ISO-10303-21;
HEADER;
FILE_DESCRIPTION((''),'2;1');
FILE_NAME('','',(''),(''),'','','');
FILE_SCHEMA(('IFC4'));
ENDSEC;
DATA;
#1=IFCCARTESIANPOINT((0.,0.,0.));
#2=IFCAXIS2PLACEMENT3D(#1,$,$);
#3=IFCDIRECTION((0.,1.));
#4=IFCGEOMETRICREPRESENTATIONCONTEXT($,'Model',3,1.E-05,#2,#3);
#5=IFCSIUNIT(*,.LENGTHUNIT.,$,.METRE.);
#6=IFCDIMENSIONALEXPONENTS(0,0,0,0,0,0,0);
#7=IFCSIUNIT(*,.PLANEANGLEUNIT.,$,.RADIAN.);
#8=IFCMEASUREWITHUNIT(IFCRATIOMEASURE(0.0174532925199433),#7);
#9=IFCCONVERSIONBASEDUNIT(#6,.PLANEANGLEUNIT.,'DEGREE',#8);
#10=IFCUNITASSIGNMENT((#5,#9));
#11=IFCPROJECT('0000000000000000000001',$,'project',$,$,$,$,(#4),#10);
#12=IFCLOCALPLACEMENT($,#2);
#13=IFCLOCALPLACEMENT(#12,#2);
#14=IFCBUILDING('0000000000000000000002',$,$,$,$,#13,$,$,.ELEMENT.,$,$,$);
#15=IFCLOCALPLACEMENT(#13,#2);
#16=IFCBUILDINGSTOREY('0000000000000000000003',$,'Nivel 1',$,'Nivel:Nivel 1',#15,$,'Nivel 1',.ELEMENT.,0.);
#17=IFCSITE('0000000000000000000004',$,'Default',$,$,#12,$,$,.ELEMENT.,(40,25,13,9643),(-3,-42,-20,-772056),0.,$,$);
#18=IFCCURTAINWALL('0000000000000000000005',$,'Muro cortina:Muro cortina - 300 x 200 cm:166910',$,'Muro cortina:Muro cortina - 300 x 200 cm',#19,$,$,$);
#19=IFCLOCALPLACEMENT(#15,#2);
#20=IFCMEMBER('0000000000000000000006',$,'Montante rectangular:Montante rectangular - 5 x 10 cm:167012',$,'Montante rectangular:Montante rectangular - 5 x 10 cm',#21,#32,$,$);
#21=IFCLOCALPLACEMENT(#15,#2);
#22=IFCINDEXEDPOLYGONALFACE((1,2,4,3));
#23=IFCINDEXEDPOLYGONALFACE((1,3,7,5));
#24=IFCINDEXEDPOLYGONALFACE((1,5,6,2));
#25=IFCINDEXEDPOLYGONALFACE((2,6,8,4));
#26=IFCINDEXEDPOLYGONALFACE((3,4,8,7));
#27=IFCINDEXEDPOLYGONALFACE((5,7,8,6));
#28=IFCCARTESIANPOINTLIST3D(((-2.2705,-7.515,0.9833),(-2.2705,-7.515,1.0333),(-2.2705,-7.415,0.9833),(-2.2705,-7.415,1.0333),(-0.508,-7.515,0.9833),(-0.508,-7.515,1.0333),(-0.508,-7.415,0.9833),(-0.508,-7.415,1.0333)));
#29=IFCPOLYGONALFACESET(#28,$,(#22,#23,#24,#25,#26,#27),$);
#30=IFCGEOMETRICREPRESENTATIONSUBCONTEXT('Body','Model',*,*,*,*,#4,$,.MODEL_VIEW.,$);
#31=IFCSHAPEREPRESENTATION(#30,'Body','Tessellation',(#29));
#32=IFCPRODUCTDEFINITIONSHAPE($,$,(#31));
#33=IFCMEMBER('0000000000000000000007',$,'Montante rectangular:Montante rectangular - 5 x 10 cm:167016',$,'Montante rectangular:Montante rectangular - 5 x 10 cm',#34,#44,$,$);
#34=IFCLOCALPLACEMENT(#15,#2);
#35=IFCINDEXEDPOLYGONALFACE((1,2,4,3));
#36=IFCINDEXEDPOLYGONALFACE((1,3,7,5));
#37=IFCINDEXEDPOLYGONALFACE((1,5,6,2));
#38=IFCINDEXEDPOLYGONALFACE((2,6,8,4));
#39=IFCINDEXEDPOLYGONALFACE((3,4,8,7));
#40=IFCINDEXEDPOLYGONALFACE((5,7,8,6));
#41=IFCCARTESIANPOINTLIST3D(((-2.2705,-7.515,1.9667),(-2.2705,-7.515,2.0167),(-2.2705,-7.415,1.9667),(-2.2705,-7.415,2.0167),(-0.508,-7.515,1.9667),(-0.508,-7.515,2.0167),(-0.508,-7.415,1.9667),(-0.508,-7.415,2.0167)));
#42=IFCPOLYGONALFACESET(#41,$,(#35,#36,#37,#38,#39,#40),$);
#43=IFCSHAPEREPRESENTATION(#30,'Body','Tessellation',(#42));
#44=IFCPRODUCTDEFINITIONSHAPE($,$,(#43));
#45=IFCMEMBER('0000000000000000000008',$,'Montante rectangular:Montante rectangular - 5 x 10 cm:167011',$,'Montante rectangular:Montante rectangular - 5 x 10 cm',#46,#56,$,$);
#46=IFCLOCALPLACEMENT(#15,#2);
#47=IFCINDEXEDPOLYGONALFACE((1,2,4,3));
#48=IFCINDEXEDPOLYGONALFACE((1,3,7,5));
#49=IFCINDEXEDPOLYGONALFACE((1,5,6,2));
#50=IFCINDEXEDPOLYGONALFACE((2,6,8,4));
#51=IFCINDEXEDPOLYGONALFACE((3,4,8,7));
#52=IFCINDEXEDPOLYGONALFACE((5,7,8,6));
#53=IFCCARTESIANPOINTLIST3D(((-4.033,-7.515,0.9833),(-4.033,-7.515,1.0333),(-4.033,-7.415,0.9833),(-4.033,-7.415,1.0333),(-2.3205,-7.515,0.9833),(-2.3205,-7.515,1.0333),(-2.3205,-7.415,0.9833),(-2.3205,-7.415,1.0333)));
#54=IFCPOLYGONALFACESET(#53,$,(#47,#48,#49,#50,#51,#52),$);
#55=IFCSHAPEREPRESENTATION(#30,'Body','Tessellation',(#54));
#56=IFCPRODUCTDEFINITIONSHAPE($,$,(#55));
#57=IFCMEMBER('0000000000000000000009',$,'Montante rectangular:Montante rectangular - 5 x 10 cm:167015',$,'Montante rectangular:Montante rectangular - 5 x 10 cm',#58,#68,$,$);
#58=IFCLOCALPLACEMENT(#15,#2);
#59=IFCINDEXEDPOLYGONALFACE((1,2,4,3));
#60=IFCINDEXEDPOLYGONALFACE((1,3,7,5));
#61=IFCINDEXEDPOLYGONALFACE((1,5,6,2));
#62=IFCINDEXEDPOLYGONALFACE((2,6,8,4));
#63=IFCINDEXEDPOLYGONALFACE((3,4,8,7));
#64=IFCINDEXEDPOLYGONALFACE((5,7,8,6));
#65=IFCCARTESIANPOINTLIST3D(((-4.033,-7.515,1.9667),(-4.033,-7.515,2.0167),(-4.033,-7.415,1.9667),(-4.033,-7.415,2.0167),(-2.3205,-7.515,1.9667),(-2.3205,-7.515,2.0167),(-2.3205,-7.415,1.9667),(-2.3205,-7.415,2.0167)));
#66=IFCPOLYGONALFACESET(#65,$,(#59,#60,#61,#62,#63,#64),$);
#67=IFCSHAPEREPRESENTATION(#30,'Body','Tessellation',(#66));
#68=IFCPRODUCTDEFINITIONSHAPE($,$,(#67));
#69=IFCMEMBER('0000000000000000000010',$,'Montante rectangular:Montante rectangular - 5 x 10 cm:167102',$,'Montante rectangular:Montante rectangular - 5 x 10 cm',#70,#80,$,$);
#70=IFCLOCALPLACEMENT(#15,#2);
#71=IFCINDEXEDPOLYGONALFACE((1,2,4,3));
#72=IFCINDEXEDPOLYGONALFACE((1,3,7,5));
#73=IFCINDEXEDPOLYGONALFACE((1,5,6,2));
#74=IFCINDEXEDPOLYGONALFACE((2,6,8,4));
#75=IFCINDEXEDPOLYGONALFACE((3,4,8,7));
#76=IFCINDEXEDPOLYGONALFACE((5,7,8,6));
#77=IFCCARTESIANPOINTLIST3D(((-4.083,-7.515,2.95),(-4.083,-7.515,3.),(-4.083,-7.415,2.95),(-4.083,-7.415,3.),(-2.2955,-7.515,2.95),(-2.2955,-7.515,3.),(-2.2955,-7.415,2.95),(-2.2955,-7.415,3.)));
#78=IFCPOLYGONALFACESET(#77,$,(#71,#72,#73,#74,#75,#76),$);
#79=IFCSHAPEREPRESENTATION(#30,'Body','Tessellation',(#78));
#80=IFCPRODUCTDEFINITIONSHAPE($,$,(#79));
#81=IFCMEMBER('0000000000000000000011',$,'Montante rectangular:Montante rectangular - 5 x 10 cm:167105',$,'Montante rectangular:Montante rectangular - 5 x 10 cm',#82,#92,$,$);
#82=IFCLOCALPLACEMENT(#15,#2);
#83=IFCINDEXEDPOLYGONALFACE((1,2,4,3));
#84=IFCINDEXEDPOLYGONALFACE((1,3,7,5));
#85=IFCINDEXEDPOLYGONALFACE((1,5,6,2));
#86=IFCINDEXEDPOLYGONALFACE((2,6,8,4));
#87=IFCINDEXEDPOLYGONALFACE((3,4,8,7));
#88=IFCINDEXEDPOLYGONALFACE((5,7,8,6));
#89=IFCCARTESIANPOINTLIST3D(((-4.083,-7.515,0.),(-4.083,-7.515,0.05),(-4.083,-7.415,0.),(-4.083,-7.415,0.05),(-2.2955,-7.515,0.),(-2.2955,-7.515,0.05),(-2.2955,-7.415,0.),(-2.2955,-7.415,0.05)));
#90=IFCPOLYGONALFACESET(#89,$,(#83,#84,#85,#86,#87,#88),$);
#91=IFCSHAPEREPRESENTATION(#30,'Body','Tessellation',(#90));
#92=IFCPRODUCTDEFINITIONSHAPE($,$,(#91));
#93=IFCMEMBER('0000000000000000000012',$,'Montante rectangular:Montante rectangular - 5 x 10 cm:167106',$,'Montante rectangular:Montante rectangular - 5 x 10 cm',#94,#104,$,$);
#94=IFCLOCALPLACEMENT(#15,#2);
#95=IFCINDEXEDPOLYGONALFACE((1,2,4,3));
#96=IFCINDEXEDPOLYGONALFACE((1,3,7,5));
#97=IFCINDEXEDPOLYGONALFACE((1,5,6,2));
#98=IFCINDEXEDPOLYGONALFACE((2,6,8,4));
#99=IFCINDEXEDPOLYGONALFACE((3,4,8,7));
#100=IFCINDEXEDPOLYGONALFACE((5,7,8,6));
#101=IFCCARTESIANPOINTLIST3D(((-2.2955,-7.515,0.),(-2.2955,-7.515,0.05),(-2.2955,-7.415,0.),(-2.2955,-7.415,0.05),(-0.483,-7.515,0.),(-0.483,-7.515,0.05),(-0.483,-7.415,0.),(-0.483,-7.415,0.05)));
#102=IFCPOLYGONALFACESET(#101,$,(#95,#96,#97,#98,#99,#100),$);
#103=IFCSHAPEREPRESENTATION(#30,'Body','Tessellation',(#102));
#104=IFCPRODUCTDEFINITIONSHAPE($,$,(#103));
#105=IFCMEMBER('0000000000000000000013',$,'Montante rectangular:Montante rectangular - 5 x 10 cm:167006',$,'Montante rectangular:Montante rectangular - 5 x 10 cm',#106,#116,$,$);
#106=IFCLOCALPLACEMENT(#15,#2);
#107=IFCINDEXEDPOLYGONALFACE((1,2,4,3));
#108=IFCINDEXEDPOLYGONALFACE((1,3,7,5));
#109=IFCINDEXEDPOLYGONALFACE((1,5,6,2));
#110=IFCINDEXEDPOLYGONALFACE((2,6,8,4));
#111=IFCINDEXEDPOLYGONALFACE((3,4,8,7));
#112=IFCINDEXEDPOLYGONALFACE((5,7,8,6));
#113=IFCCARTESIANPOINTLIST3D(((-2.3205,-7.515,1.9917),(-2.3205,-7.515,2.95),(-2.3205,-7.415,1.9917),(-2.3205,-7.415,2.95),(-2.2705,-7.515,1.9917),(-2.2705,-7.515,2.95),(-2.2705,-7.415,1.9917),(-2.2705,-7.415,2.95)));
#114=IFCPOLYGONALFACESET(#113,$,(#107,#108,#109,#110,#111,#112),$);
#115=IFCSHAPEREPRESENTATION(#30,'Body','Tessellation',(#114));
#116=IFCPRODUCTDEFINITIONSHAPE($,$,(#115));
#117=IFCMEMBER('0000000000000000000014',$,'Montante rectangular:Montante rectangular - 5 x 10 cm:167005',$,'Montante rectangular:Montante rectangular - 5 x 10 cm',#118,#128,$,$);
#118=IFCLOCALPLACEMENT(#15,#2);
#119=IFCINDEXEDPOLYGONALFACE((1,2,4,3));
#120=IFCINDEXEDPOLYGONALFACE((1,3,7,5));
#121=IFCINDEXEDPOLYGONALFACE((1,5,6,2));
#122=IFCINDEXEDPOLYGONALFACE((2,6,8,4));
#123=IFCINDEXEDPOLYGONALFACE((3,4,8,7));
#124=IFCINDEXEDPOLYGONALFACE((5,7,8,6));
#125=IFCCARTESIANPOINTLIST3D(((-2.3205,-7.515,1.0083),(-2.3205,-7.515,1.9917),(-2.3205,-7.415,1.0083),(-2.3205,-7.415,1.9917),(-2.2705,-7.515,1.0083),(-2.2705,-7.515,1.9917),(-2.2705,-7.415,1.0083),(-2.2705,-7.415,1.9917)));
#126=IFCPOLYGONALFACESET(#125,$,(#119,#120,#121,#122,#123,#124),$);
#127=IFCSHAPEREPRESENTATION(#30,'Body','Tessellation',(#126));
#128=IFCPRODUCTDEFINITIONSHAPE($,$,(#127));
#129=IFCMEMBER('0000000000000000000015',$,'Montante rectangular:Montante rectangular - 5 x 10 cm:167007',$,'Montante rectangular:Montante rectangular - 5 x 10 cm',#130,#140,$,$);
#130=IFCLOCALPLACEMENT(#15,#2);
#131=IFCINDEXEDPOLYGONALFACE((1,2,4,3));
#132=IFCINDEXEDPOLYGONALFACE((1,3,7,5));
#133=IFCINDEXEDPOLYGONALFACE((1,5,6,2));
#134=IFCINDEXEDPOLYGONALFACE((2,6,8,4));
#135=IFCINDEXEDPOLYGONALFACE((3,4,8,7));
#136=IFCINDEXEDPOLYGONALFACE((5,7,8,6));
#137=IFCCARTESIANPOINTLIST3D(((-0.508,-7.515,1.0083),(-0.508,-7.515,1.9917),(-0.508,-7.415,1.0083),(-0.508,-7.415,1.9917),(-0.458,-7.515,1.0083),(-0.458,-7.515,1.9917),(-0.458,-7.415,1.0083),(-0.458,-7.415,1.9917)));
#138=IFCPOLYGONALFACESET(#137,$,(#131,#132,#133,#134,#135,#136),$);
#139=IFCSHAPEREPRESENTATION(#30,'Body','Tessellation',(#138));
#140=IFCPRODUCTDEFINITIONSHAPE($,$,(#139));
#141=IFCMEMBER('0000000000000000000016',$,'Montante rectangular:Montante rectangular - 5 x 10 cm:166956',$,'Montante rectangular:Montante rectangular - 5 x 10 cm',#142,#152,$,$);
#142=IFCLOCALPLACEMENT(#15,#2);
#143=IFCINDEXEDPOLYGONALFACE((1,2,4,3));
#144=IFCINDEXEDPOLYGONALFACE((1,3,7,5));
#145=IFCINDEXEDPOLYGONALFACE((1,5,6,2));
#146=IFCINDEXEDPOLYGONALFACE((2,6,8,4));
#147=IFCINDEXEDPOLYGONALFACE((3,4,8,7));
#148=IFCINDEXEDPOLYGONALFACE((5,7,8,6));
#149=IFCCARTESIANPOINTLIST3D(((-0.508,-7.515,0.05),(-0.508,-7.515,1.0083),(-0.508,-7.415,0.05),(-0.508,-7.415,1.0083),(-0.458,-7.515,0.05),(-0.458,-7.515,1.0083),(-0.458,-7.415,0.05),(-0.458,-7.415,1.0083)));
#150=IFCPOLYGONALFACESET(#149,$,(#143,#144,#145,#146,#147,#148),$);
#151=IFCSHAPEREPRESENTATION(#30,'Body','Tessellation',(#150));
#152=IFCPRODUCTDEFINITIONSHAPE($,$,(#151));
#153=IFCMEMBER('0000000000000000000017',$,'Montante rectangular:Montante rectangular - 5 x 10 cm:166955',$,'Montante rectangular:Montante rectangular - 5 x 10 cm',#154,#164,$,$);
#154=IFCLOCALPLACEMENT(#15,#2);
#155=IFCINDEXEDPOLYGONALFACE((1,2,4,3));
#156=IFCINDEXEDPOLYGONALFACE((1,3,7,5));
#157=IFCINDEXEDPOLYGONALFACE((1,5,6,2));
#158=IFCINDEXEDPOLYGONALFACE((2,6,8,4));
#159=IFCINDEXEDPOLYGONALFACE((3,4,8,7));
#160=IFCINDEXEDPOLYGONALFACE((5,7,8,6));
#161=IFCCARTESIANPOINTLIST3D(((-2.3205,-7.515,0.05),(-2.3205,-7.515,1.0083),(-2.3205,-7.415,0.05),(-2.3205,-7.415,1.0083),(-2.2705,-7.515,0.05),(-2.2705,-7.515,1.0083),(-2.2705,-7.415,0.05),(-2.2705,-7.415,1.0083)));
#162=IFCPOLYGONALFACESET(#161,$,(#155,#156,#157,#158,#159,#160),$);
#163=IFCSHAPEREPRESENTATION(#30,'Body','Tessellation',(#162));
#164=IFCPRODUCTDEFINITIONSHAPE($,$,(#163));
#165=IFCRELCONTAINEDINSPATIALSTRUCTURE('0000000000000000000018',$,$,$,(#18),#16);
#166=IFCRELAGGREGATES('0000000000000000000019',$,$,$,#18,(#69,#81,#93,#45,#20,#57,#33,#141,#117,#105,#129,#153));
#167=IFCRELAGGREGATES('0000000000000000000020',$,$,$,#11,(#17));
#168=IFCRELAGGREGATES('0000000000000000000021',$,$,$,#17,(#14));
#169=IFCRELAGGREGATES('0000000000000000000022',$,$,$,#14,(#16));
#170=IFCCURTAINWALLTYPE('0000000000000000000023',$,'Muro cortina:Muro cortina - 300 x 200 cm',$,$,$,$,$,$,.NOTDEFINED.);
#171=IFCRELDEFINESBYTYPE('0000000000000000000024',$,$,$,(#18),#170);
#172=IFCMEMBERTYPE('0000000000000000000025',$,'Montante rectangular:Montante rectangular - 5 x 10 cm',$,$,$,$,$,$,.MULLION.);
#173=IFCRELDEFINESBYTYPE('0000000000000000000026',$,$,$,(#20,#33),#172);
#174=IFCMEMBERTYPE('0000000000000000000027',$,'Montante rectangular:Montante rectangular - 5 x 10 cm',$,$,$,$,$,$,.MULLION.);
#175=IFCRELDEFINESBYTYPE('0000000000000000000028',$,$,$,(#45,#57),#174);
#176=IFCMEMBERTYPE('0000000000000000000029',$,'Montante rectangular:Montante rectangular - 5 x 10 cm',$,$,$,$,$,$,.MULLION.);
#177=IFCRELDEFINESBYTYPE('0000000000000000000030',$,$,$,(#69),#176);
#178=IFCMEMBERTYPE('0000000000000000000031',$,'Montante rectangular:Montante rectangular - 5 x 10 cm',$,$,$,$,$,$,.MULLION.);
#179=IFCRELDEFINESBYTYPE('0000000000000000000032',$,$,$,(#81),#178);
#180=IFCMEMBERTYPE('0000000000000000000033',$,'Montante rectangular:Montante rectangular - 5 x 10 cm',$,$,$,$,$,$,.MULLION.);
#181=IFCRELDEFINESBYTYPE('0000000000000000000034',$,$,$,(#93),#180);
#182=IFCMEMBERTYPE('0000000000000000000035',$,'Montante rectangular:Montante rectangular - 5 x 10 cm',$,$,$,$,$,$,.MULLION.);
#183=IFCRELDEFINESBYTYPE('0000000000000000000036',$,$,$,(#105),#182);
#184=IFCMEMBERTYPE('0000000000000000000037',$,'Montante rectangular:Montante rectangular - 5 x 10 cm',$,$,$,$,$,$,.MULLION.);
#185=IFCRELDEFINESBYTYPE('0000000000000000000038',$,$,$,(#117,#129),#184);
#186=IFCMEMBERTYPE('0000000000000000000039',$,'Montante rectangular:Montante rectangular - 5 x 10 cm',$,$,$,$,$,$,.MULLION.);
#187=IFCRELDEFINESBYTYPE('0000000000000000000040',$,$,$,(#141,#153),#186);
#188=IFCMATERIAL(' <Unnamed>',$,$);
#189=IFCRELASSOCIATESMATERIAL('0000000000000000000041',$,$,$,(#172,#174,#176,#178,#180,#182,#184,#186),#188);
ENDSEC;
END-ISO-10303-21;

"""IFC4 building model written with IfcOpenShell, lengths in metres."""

from ifc_helpers import new_model, entity, si_unit, converted_unit, direction, frame, origin, origin_2d_with_axis, place, context, subcontext, project, spatial, rectangle, extrude, source, transform, mapped, material, type_object, type_shapes, element, aggregate, save


model = new_model("IFC4")

# Units and contexts
model_context = context("Model", 3, precision=1e-05, world=origin(), true_north=direction((0.0, 1.0)))
body_context = subcontext(model_context, "Body", "Model", "MODEL_VIEW")
ifc_project = project(units=[si_unit("LENGTHUNIT", "METRE"), converted_unit("PLANEANGLEUNIT", "DEGREE", entity("IfcRatioMeasure", 0.0174532925199433), si_unit("PLANEANGLEUNIT", "RADIAN"), dimensions=[0, 0, 0, 0, 0, 0, 0])], contexts=[model_context])

# Site, building, storey
site_placement = place(None, origin())
site = spatial("IfcSite", under=ifc_project, at=site_placement, Name="Default", CompositionType="ELEMENT", RefLatitude=(40, 25, 13, 9643), RefLongitude=(-3, -42, -20, -772056), RefElevation=0.0)
building_placement = place(site_placement, origin())
building = spatial("IfcBuilding", under=site, at=building_placement, CompositionType="ELEMENT")
storey_placement = place(building_placement, origin())
storey = spatial("IfcBuildingStorey", under=building, at=storey_placement, Name="Nivel 1", ObjectType="Nivel:Nivel 1", LongName="Nivel 1", CompositionType="ELEMENT", Elevation=0.0)

# Curtain wall, members
curtain_wall_type = type_object("IfcCurtainWallType", Name="Muro cortina:Muro cortina - 300 x 200 cm", PredefinedType="NOTDEFINED")
curtain_wall_placement = place(storey_placement, origin())
curtain_wall = element("IfcCurtainWall", 1, at=curtain_wall_placement, inside=storey, type_object=curtain_wall_type, Name="Muro cortina:Muro cortina - 300 x 200 cm:166910", ObjectType="Muro cortina:Muro cortina - 300 x 200 cm")
ifc_material_1 = material(Name=" <Unnamed>")
member_type_1 = type_object("IfcMemberType", Name="Montante rectangular:Montante rectangular - 5 x 10 cm", PredefinedType="MULLION", material=ifc_material_1)
shared_shape_1 = source(origin(), body_context, "Body", "SweptSolid", [
    extrude(rectangle(XDim=0.1, YDim=0.05, at=origin_2d_with_axis()), frame((0.0, 0.0, -1.7625), z_axis=(0.0, 0.0, 1.0), x_axis=(0.0, -1.0, 0.0)), (0.0, 0.0, 1.0), 1.7625),
])
type_shapes(member_type_1, [shared_shape_1])
member_1_placement = place(storey_placement, frame((-0.508, -7.465, 1.0083), z_axis=(1.0, 0.0, 0.0), x_axis=(0.0, 0.0, 1.0)))
member_1 = element("IfcMember", 2, at=member_1_placement, type_object=member_type_1, Name="Montante rectangular:Montante rectangular - 5 x 10 cm:167012", ObjectType="Montante rectangular:Montante rectangular - 5 x 10 cm", context=body_context, shape_type="MappedRepresentation", body=[
    mapped(shared_shape_1, transform((0.0, 0.0, 0.0), scale=1.0)),
])
member_2_placement = place(storey_placement, frame((-0.508, -7.465, 1.9917), z_axis=(1.0, 0.0, 0.0), x_axis=(0.0, 0.0, 1.0)))
member_2 = element("IfcMember", 3, at=member_2_placement, type_object=member_type_1, Name="Montante rectangular:Montante rectangular - 5 x 10 cm:167016", ObjectType="Montante rectangular:Montante rectangular - 5 x 10 cm", context=body_context, shape_type="MappedRepresentation", body=[
    mapped(shared_shape_1, transform((0.0, 0.0, 0.0), scale=1.0)),
])
member_type_2 = type_object("IfcMemberType", Name="Montante rectangular:Montante rectangular - 5 x 10 cm", PredefinedType="MULLION", material=ifc_material_1)
shared_shape_2 = source(origin(), body_context, "Body", "SweptSolid", [
    extrude(rectangle(XDim=0.1, YDim=0.05, at=origin_2d_with_axis()), frame((0.0, 0.0, -1.7125), z_axis=(0.0, 0.0, 1.0), x_axis=(0.0, -1.0, 0.0)), (0.0, 0.0, 1.0), 1.7125),
])
type_shapes(member_type_2, [shared_shape_2])
member_3_placement = place(storey_placement, frame((-2.3205, -7.465, 1.0083), z_axis=(1.0, 0.0, 0.0), x_axis=(0.0, 0.0, 1.0)))
member_3 = element("IfcMember", 4, at=member_3_placement, type_object=member_type_2, Name="Montante rectangular:Montante rectangular - 5 x 10 cm:167011", ObjectType="Montante rectangular:Montante rectangular - 5 x 10 cm", context=body_context, shape_type="MappedRepresentation", body=[
    mapped(shared_shape_2, transform((0.0, 0.0, 0.0), scale=1.0)),
])
member_4_placement = place(storey_placement, frame((-2.3205, -7.465, 1.9917), z_axis=(1.0, 0.0, 0.0), x_axis=(0.0, 0.0, 1.0)))
member_4 = element("IfcMember", 5, at=member_4_placement, type_object=member_type_2, Name="Montante rectangular:Montante rectangular - 5 x 10 cm:167015", ObjectType="Montante rectangular:Montante rectangular - 5 x 10 cm", context=body_context, shape_type="MappedRepresentation", body=[
    mapped(shared_shape_2, transform((0.0, 0.0, 0.0), scale=1.0)),
])
member_type_3 = type_object("IfcMemberType", Name="Montante rectangular:Montante rectangular - 5 x 10 cm", PredefinedType="MULLION", material=ifc_material_1)
shared_shape_3 = source(origin(), body_context, "Body", "SweptSolid", [
    extrude(rectangle(XDim=0.1, YDim=0.05, at=origin_2d_with_axis()), frame((-0.025, 0.0, -1.7875), z_axis=(0.0, 0.0, 1.0), x_axis=(0.0, -1.0, 0.0)), (0.0, 0.0, 1.0), 1.7875),
])
type_shapes(member_type_3, [shared_shape_3])
member_5_placement = place(storey_placement, frame((-2.2955, -7.465, 3.0), z_axis=(1.0, 0.0, 0.0), x_axis=(0.0, 0.0, 1.0)))
member_5 = element("IfcMember", 6, at=member_5_placement, type_object=member_type_3, Name="Montante rectangular:Montante rectangular - 5 x 10 cm:167102", ObjectType="Montante rectangular:Montante rectangular - 5 x 10 cm", context=body_context, shape_type="MappedRepresentation", body=[
    mapped(shared_shape_3, transform((0.0, 0.0, 0.0), scale=1.0)),
])
member_type_4 = type_object("IfcMemberType", Name="Montante rectangular:Montante rectangular - 5 x 10 cm", PredefinedType="MULLION", material=ifc_material_1)
shared_shape_4 = source(origin(), body_context, "Body", "SweptSolid", [
    extrude(rectangle(XDim=0.1, YDim=0.05, at=origin_2d_with_axis()), frame((-0.025, 0.0, -1.7875), z_axis=(0.0, 0.0, 1.0), x_axis=(0.0, -1.0, 0.0)), (0.0, 0.0, 1.0), 1.7875),
])
type_shapes(member_type_4, [shared_shape_4])
member_6_placement = place(storey_placement, frame((-4.083, -7.465, 0.0), z_axis=(-1.0, 0.0, 0.0), x_axis=(0.0, 0.0, -1.0)))
member_6 = element("IfcMember", 7, at=member_6_placement, type_object=member_type_4, Name="Montante rectangular:Montante rectangular - 5 x 10 cm:167105", ObjectType="Montante rectangular:Montante rectangular - 5 x 10 cm", context=body_context, shape_type="MappedRepresentation", body=[
    mapped(shared_shape_4, transform((0.0, 0.0, 0.0), scale=1.0)),
])
member_type_5 = type_object("IfcMemberType", Name="Montante rectangular:Montante rectangular - 5 x 10 cm", PredefinedType="MULLION", material=ifc_material_1)
shared_shape_5 = source(origin(), body_context, "Body", "SweptSolid", [
    extrude(rectangle(XDim=0.1, YDim=0.05, at=origin_2d_with_axis()), frame((-0.025, 0.0, -1.8125), z_axis=(0.0, 0.0, 1.0), x_axis=(0.0, -1.0, 0.0)), (0.0, 0.0, 1.0), 1.8125),
])
type_shapes(member_type_5, [shared_shape_5])
member_7_placement = place(storey_placement, frame((-2.2955, -7.465, 0.0), z_axis=(-1.0, 0.0, 0.0), x_axis=(0.0, 0.0, -1.0)))
member_7 = element("IfcMember", 8, at=member_7_placement, type_object=member_type_5, Name="Montante rectangular:Montante rectangular - 5 x 10 cm:167106", ObjectType="Montante rectangular:Montante rectangular - 5 x 10 cm", context=body_context, shape_type="MappedRepresentation", body=[
    mapped(shared_shape_5, transform((0.0, 0.0, 0.0), scale=1.0)),
])
member_type_6 = type_object("IfcMemberType", Name="Montante rectangular:Montante rectangular - 5 x 10 cm", PredefinedType="MULLION", material=ifc_material_1)
shared_shape_6 = source(origin(), body_context, "Body", "SweptSolid", [
    extrude(rectangle(XDim=0.1, YDim=0.05, at=origin_2d_with_axis()), frame((0.0, 0.0, -0.9583), z_axis=(0.0, 0.0, 1.0), x_axis=(0.0, -1.0, 0.0)), (0.0, 0.0, 1.0), 0.9583),
])
type_shapes(member_type_6, [shared_shape_6])
member_8_placement = place(storey_placement, frame((-2.2955, -7.465, 1.9917), z_axis=(0.0, 0.0, -1.0), x_axis=(1.0, 0.0, 0.0)))
member_8 = element("IfcMember", 9, at=member_8_placement, type_object=member_type_6, Name="Montante rectangular:Montante rectangular - 5 x 10 cm:167006", ObjectType="Montante rectangular:Montante rectangular - 5 x 10 cm", context=body_context, shape_type="MappedRepresentation", body=[
    mapped(shared_shape_6, transform((0.0, 0.0, 0.0), scale=1.0)),
])
member_type_7 = type_object("IfcMemberType", Name="Montante rectangular:Montante rectangular - 5 x 10 cm", PredefinedType="MULLION", material=ifc_material_1)
shared_shape_7 = source(origin(), body_context, "Body", "SweptSolid", [
    extrude(rectangle(XDim=0.1, YDim=0.05, at=origin_2d_with_axis()), frame((0.0, 0.0, -0.9833), z_axis=(0.0, 0.0, 1.0), x_axis=(0.0, -1.0, 0.0)), (0.0, 0.0, 1.0), 0.9833),
])
type_shapes(member_type_7, [shared_shape_7])
member_9_placement = place(storey_placement, frame((-2.2955, -7.465, 1.0083), z_axis=(0.0, 0.0, -1.0), x_axis=(1.0, 0.0, 0.0)))
member_9 = element("IfcMember", 10, at=member_9_placement, type_object=member_type_7, Name="Montante rectangular:Montante rectangular - 5 x 10 cm:167005", ObjectType="Montante rectangular:Montante rectangular - 5 x 10 cm", context=body_context, shape_type="MappedRepresentation", body=[
    mapped(shared_shape_7, transform((0.0, 0.0, 0.0), scale=1.0)),
])
member_10_placement = place(storey_placement, frame((-0.483, -7.465, 1.0083), z_axis=(0.0, 0.0, -1.0), x_axis=(1.0, 0.0, 0.0)))
member_10 = element("IfcMember", 11, at=member_10_placement, type_object=member_type_7, Name="Montante rectangular:Montante rectangular - 5 x 10 cm:167007", ObjectType="Montante rectangular:Montante rectangular - 5 x 10 cm", context=body_context, shape_type="MappedRepresentation", body=[
    mapped(shared_shape_7, transform((0.0, 0.0, 0.0), scale=1.0)),
])
member_type_8 = type_object("IfcMemberType", Name="Montante rectangular:Montante rectangular - 5 x 10 cm", PredefinedType="MULLION", material=ifc_material_1)
shared_shape_8 = source(origin(), body_context, "Body", "SweptSolid", [
    extrude(rectangle(XDim=0.1, YDim=0.05, at=origin_2d_with_axis()), frame((0.0, 0.0, -0.9583), z_axis=(0.0, 0.0, 1.0), x_axis=(0.0, -1.0, 0.0)), (0.0, 0.0, 1.0), 0.9583),
])
type_shapes(member_type_8, [shared_shape_8])
member_11_placement = place(storey_placement, frame((-0.483, -7.465, 0.05), z_axis=(0.0, 0.0, -1.0), x_axis=(1.0, 0.0, 0.0)))
member_11 = element("IfcMember", 12, at=member_11_placement, type_object=member_type_8, Name="Montante rectangular:Montante rectangular - 5 x 10 cm:166956", ObjectType="Montante rectangular:Montante rectangular - 5 x 10 cm", context=body_context, shape_type="MappedRepresentation", body=[
    mapped(shared_shape_8, transform((0.0, 0.0, 0.0), scale=1.0)),
])
member_12_placement = place(storey_placement, frame((-2.2955, -7.465, 0.05), z_axis=(0.0, 0.0, -1.0), x_axis=(1.0, 0.0, 0.0)))
member_12 = element("IfcMember", 13, at=member_12_placement, type_object=member_type_8, Name="Montante rectangular:Montante rectangular - 5 x 10 cm:166955", ObjectType="Montante rectangular:Montante rectangular - 5 x 10 cm", context=body_context, shape_type="MappedRepresentation", body=[
    mapped(shared_shape_8, transform((0.0, 0.0, 0.0), scale=1.0)),
])
aggregate(curtain_wall, [member_5, member_6, member_7, member_3, member_1, member_4, member_2, member_11, member_9, member_8, member_10, member_12])

save(model, "model.ifc")
